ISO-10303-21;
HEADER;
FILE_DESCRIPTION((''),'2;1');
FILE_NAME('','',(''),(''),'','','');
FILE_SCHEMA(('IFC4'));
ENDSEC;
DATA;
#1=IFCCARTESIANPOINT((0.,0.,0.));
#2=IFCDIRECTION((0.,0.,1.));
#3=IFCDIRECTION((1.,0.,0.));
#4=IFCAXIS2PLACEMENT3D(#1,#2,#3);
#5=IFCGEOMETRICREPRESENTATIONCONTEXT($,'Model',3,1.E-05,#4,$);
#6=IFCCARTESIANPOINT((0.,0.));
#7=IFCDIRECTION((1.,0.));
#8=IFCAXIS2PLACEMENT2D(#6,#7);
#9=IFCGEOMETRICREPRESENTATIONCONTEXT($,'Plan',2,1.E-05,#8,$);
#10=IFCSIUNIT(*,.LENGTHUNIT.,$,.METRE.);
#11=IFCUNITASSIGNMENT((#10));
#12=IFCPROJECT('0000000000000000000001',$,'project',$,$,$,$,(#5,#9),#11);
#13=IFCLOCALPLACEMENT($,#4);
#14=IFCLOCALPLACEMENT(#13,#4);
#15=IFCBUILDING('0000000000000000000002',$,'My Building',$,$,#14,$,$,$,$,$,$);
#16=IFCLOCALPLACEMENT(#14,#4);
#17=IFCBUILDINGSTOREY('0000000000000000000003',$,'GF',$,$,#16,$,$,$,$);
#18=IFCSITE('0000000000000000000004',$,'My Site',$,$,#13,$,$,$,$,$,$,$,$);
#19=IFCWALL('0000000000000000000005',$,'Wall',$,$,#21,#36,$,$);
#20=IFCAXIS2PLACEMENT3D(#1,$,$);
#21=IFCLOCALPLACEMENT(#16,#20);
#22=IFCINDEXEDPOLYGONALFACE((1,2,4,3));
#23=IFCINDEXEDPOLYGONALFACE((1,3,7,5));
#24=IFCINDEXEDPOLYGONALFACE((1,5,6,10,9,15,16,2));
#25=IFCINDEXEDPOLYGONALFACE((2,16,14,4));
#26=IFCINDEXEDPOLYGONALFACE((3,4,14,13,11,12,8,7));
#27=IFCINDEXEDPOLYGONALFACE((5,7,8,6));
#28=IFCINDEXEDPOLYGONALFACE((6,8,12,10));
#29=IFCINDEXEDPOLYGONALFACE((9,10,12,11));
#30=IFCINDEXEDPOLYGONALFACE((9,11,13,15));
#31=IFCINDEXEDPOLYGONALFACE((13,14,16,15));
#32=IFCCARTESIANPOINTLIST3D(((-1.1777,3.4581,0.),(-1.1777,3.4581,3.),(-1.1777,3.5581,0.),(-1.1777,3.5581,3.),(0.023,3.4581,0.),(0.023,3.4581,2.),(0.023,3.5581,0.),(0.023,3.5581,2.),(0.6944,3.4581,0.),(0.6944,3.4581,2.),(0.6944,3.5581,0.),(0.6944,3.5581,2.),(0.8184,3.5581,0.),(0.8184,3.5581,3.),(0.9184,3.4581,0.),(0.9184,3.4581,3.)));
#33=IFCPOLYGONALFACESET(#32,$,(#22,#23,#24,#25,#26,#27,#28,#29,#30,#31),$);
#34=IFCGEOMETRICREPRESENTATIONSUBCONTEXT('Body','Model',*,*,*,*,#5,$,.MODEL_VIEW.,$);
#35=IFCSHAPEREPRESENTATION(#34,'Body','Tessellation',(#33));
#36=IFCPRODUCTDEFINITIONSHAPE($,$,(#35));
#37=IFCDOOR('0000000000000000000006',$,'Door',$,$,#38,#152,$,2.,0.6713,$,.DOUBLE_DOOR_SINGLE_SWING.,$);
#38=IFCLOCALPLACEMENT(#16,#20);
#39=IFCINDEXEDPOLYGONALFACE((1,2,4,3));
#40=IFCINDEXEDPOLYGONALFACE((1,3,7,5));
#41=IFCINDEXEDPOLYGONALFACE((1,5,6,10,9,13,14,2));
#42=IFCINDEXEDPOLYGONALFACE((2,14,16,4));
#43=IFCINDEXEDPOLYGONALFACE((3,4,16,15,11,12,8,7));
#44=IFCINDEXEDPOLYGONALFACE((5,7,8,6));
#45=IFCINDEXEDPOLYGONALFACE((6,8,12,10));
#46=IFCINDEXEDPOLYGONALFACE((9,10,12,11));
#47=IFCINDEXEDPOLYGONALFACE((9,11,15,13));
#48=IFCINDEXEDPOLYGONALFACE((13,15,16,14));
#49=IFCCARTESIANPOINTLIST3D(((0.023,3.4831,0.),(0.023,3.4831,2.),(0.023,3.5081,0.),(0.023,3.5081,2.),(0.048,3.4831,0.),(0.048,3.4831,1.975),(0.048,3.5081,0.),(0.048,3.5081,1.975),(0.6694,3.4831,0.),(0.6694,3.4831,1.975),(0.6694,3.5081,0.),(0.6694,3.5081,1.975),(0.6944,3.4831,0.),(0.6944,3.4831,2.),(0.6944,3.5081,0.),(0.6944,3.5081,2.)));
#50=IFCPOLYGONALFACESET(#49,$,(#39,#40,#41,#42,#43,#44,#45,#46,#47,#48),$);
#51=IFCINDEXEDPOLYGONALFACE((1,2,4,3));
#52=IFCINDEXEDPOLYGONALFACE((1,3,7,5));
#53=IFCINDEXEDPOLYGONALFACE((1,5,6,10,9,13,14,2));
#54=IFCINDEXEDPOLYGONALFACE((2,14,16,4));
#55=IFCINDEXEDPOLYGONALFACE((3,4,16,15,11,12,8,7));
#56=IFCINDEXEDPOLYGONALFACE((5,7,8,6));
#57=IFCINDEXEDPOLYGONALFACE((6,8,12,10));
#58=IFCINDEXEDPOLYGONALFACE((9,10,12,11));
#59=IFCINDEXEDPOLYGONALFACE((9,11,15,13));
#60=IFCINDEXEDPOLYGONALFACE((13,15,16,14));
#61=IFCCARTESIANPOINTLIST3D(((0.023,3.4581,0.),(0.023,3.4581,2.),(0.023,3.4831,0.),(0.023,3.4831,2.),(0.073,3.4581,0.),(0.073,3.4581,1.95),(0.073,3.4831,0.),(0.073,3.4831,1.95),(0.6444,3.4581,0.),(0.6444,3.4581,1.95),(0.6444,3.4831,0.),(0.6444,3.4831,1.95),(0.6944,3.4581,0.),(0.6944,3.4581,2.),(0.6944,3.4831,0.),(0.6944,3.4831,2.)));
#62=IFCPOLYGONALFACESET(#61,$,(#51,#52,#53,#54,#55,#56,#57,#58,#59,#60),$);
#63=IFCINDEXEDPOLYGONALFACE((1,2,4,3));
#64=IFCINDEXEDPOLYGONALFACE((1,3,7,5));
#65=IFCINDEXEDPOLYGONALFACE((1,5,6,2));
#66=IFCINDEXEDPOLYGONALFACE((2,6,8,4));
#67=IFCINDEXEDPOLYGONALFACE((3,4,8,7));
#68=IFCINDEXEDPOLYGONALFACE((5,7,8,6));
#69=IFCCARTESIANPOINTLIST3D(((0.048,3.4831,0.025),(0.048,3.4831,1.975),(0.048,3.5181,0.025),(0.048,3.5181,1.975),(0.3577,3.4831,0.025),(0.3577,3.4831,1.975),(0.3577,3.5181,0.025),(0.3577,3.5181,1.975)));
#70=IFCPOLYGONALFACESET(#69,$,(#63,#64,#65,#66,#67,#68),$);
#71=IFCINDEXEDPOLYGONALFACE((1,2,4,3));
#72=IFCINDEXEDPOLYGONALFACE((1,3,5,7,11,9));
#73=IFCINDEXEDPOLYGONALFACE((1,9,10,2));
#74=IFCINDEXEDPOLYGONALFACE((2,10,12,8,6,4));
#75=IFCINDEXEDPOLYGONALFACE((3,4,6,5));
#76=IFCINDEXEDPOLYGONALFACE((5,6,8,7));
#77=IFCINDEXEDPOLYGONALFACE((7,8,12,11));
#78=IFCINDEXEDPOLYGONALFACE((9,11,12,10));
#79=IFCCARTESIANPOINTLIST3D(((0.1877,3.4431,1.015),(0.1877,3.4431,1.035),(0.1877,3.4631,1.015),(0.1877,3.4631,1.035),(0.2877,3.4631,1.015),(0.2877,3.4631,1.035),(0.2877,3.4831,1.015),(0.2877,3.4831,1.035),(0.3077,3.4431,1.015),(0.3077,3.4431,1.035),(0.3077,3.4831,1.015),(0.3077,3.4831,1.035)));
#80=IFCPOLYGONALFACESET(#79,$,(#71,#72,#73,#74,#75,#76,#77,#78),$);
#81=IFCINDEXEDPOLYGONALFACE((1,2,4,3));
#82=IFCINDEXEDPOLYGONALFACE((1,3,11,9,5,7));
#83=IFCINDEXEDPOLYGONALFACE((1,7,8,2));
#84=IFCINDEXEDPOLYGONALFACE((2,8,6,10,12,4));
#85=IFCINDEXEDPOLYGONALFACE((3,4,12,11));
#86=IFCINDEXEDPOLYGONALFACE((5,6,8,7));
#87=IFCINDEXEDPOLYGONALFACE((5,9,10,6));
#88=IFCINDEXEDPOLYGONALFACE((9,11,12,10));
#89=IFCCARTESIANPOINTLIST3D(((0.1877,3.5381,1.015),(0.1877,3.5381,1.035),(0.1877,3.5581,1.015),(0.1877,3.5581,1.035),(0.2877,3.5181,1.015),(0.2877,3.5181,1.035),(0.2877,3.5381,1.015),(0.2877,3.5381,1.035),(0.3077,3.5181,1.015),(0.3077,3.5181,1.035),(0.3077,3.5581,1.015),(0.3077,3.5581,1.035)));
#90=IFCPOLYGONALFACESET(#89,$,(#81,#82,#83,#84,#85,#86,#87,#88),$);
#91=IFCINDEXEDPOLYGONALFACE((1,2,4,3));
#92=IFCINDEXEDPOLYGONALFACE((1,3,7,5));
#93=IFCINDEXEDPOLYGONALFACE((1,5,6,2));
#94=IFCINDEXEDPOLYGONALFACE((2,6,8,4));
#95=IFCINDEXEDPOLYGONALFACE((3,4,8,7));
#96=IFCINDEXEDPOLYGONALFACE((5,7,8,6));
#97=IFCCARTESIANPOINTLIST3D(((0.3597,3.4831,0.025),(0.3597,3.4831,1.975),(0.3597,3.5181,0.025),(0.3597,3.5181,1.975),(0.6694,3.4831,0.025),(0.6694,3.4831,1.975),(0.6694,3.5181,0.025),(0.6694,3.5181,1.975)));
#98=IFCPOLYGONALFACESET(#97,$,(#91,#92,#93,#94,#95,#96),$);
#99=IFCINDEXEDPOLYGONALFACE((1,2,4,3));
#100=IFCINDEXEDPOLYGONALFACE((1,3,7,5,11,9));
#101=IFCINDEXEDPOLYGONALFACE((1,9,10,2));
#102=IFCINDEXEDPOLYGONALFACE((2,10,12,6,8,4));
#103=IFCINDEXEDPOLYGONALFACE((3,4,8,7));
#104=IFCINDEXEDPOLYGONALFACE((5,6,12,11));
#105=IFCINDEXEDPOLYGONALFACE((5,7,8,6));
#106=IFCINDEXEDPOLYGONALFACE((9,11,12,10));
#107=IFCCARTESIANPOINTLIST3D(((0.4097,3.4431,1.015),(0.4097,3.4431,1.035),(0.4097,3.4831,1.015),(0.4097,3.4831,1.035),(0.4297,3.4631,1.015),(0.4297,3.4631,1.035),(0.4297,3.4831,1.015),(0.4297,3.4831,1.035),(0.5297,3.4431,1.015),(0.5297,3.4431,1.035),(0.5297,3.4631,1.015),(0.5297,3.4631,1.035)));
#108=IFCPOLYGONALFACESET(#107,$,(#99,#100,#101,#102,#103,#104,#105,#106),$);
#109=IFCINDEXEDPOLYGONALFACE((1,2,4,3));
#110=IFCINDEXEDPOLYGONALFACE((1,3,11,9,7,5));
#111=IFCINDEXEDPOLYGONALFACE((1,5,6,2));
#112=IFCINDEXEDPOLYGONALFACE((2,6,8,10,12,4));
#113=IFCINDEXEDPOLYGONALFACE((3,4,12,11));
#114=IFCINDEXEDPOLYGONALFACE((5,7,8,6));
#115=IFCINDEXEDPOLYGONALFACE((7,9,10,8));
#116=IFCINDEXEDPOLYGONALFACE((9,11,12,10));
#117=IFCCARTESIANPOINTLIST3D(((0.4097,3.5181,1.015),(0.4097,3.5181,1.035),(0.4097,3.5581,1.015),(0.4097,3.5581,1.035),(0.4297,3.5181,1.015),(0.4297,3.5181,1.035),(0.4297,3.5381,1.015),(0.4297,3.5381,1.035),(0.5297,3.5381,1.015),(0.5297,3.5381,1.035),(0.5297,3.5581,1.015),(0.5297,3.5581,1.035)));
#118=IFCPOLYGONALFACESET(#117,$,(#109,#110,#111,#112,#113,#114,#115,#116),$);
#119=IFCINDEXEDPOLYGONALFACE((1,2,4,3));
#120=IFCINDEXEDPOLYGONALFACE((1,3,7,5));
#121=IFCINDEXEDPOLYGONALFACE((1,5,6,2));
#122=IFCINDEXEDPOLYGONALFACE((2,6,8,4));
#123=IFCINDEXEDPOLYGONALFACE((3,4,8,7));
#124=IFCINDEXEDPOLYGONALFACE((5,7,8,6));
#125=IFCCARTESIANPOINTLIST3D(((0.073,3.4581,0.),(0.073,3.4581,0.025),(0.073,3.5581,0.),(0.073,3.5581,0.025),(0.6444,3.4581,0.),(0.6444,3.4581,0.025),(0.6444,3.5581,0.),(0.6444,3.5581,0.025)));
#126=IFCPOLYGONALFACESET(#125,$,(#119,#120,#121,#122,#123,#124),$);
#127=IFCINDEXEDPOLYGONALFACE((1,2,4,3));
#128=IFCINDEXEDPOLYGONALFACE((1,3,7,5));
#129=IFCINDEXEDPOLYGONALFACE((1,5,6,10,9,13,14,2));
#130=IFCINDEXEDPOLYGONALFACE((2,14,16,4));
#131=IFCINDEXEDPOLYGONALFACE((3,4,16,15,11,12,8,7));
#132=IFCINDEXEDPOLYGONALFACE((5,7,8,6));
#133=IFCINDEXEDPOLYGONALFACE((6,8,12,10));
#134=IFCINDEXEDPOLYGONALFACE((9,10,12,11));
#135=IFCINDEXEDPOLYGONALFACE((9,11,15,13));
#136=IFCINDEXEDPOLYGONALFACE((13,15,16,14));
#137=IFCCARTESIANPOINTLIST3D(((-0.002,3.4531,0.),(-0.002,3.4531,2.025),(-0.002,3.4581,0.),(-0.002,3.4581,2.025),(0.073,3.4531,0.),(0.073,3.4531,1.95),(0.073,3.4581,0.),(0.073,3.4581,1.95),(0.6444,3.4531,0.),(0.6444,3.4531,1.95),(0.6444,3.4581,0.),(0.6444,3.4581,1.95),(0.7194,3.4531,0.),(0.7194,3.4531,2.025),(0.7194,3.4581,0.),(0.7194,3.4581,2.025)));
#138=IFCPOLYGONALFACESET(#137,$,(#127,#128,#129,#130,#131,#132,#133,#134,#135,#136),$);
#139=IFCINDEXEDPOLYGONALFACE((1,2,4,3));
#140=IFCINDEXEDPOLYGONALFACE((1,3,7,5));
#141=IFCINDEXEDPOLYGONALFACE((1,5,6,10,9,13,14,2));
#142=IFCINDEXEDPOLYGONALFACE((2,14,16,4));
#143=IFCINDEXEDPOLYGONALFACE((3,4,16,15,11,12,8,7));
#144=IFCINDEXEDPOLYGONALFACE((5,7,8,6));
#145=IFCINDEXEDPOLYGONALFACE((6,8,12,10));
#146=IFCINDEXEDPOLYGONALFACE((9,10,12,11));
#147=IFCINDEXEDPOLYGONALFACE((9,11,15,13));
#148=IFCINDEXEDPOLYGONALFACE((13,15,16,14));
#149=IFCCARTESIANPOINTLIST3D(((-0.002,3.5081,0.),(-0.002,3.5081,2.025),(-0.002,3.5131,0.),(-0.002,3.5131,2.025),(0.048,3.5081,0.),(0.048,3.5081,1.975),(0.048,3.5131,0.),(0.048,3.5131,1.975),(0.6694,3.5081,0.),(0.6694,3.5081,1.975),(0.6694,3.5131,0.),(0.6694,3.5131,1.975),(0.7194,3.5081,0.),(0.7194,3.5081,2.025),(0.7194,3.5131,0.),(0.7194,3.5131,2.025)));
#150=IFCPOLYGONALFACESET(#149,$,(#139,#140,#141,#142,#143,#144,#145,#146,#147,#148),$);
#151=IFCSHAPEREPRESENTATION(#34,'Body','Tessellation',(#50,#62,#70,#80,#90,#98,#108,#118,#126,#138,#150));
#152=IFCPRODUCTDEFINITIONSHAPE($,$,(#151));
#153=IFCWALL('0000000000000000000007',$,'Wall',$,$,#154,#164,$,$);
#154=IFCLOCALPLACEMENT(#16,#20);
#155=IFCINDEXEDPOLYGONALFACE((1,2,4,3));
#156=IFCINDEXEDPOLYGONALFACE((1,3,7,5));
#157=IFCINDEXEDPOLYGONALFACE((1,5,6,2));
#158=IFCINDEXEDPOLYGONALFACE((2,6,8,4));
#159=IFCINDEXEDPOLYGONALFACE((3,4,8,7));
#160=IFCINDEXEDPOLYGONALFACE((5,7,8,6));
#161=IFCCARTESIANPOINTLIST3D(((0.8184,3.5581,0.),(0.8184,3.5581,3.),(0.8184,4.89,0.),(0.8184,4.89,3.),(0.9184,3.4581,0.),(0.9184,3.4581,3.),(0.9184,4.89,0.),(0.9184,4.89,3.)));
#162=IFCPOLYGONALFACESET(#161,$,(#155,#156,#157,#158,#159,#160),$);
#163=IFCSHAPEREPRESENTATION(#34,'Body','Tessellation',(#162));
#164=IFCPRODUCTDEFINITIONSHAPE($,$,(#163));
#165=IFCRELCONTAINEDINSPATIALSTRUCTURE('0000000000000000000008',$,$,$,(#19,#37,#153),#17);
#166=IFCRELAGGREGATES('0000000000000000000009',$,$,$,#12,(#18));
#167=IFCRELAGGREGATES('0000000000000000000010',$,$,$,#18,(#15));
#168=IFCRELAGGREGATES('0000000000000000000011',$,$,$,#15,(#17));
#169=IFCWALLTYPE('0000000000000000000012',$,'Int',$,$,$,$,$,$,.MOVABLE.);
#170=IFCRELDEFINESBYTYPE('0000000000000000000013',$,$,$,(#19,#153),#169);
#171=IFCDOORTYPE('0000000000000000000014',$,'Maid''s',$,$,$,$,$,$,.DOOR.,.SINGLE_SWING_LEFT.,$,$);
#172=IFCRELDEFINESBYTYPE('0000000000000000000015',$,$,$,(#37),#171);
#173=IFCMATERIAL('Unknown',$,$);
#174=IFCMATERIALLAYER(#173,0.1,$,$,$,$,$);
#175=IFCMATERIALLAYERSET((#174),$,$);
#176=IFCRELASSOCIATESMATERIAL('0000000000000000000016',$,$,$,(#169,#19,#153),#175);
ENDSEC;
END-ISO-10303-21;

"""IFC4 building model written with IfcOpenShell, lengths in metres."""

from ifc_helpers import new_model, entity, si_unit, frame, origin_with_axes, origin_2d_with_axis, place, context, subcontext, project, spatial, line, indexed_curve, outline, extrude, shape, source, transform, mapped, material, layer, layer_set, layer_usage, type_object, type_shapes, element, fill, save


model = new_model("IFC4")

# Units and contexts
model_context = context("Model", 3, precision=1e-05, world=origin_with_axes())
plan_context = context("Plan", 2, precision=1e-05, world=origin_2d_with_axis())
body_context_1 = subcontext(model_context, "Body", "Model", "MODEL_VIEW")
body_context_2 = subcontext(plan_context, "Body", "Plan", "PLAN_VIEW")
ifc_project = project(units=[si_unit("LENGTHUNIT", "METRE")], contexts=[model_context, plan_context])

# Site, building, storey
site_placement = place(None, origin_with_axes())
site = spatial("IfcSite", under=ifc_project, at=site_placement, Name="My Site")
building_placement = place(site_placement, origin_with_axes())
building = spatial("IfcBuilding", under=site, at=building_placement, Name="My Building")
storey_placement = place(building_placement, origin_with_axes())
storey = spatial("IfcBuildingStorey", under=building, at=storey_placement, Name="GF")

# Shared definitions
ifc_material = material(Name="Unknown")

# Shared definitions
ifc_layer_1 = layer(ifc_material, 0.1)
ifc_layer_set_1 = layer_set([ifc_layer_1])
wall_type_1 = type_object("IfcWallType", Name="Int", PredefinedType="MOVABLE", material=ifc_layer_set_1)

# Wall, opening, door
ifc_layer_usage_1 = layer_usage(ifc_layer_set_1, "AXIS2", "POSITIVE", 0.0)
wall_1_placement = place(storey_placement, frame((-1.1777, 3.4581, 0.0), z_axis=(0.0, 0.0, 1.0), x_axis=(1.0, 0.0, 0.0)))
wall_1 = element("IfcWall", 1, at=wall_1_placement, inside=storey, type_object=wall_type_1, material=ifc_layer_usage_1, Name="Wall", context=body_context_1, shape_type="SweptSolid", body=[
    extrude(outline(indexed_curve([(0.0, 0.0), (0.0, 0.1), (1.9961, 0.1), (2.0961, 0.0)], segments=[line(1, 2, 3, 4, 1)])), origin_with_axes(), (0.0, 0.0, 1.0), 3.0),
])
shared_shape_1 = source(origin_with_axes(), body_context_1, "Body", "SweptSolid", [
    extrude(outline(indexed_curve([(0.0, 0.0), (0.6713, 0.0), (0.6713, 2.0), (0.0, 2.0)], segments=[line(1, 2, 3, 4, 1)])), frame((0.0, -0.6, 0.0), z_axis=(0.0, -1.0, 0.0), x_axis=(1.0, 0.0, 0.0)), (0.0, 0.0, -1.0), 1.2),
])
opening_1_placement = place(wall_1_placement, frame((1.2007, 0.0, 0.0), z_axis=(0.0, 0.0, 1.0), x_axis=(1.0, 0.0, 0.0)))
opening_1 = element("IfcOpeningElement", 2, at=opening_1_placement, cuts=wall_1, PredefinedType="OPENING", context=body_context_1, shape_type="MappedRepresentation", body=[
    mapped(shared_shape_1, transform((0.0, 0.0, 0.0), x_axis=(1.0, 0.0, 0.0), y_axis=(0.0, 1.0, 0.0), z_axis=(0.0, 0.0, 1.0), scale=1.0)),
])
door_type_1 = type_object("IfcDoorType", Name="Maid's", OperationType="SINGLE_SWING_LEFT", PredefinedType="DOOR")
shared_shape_2 = source(origin_with_axes(), body_context_1, "Body", "SweptSolid", [
    extrude(outline(indexed_curve([(0.0, 0.0), (0.0, 2.0), (0.6713, 2.0), (0.6713, 0.0), (0.6463, 0.0), (0.6463, 1.975), (0.025, 1.975), (0.025, 0.0)], segments=[line(1, 2, 3, 4, 5, 6, 7, 8, 1)])), frame((0.0, 0.025, 0.0), z_axis=(0.0, -1.0, 0.0), x_axis=(1.0, 0.0, 0.0)), (0.0, 0.0, -1.0), 0.025),
    extrude(outline(indexed_curve([(0.0, 0.0), (0.0, 2.0), (0.6713, 2.0), (0.6713, 0.0), (0.6213, 0.0), (0.6213, 1.95), (0.05, 1.95), (0.05, 0.0)], segments=[line(1, 2, 3, 4, 5, 6, 7, 8, 1)])), frame((0.0, 0.0, 0.0), z_axis=(0.0, -1.0, 0.0), x_axis=(1.0, 0.0, 0.0)), (0.0, 0.0, -1.0), 0.025),
    extrude(outline(indexed_curve([(0.0, 0.0), (0.3097, 0.0), (0.3097, 0.035), (0.0, 0.035)], segments=[line(1, 2, 3, 4, 1)])), frame((0.025, 0.025, 0.025), z_axis=(0.0, 0.0, 1.0), x_axis=(1.0, 0.0, 0.0)), (0.0, 0.0, 1.0), 1.95),
    extrude(outline(indexed_curve([(0.0, 0.0), (0.0, -0.04), (-0.12, -0.04), (-0.12, -0.02), (-0.02, -0.02), (-0.02, 0.0)], segments=[line(1, 2, 3, 4, 5, 6, 1)])), frame((0.2847, 0.025, 1.015), z_axis=(0.0, 0.0, 1.0), x_axis=(1.0, 0.0, 0.0)), (0.0, 0.0, 1.0), 0.02),
    extrude(outline(indexed_curve([(0.0, 0.0), (0.0, 0.04), (-0.12, 0.04), (-0.12, 0.02), (-0.02, 0.02), (-0.02, 0.0)], segments=[line(1, 2, 3, 4, 5, 6, 1)])), frame((0.2847, 0.06, 1.015), z_axis=(0.0, 0.0, 1.0), x_axis=(1.0, 0.0, 0.0)), (0.0, 0.0, 1.0), 0.02),
    extrude(outline(indexed_curve([(0.0, 0.0), (-0.3097, 0.0), (-0.3097, 0.035), (0.0, 0.035)], segments=[line(1, 2, 3, 4, 1)])), frame((0.6463, 0.025, 0.025), z_axis=(0.0, 0.0, 1.0), x_axis=(1.0, 0.0, 0.0)), (0.0, 0.0, 1.0), 1.95),
    extrude(outline(indexed_curve([(0.0, 0.0), (0.0, -0.04), (0.12, -0.04), (0.12, -0.02), (0.02, -0.02), (0.02, 0.0)], segments=[line(1, 2, 3, 4, 5, 6, 1)])), frame((0.3867, 0.025, 1.015), z_axis=(0.0, 0.0, 1.0), x_axis=(1.0, 0.0, 0.0)), (0.0, 0.0, 1.0), 0.02),
    extrude(outline(indexed_curve([(0.0, 0.0), (0.0, 0.04), (0.12, 0.04), (0.12, 0.02), (0.02, 0.02), (0.02, 0.0)], segments=[line(1, 2, 3, 4, 5, 6, 1)])), frame((0.3867, 0.06, 1.015), z_axis=(0.0, 0.0, 1.0), x_axis=(1.0, 0.0, 0.0)), (0.0, 0.0, 1.0), 0.02),
    extrude(outline(indexed_curve([(0.0, 0.1), (0.5713, 0.1), (0.5713, 0.0), (0.0, 0.0), (0.0, 0.1)])), frame((0.05, 0.0, 0.0), z_axis=(0.0, 0.0, 1.0), x_axis=(1.0, 0.0, 0.0)), (0.0, 0.0, 1.0), 0.025),
    extrude(outline(indexed_curve([(0.075, 0.0), (0.075, 1.95), (0.6463, 1.95), (0.6463, 0.0), (0.7213, 0.0), (0.7213, 2.025), (0.0, 2.025), (0.0, 0.0), (0.075, 0.0)])), frame((-0.025, -0.005, 0.0), z_axis=(0.0, -1.0, 0.0), x_axis=(1.0, 0.0, 0.0)), (0.0, 0.0, -1.0), 0.005),
    extrude(outline(indexed_curve([(0.0, 0.0), (0.0, 2.025), (0.7213, 2.025), (0.7213, 0.0), (0.6713, 0.0), (0.6713, 1.975), (0.05, 1.975), (0.05, 0.0)], segments=[line(1, 2, 3, 4, 5, 6, 7, 8, 1)])), frame((-0.025, 0.05, 0.0), z_axis=(0.0, -1.0, 0.0), x_axis=(1.0, 0.0, 0.0)), (0.0, 0.0, -1.0), 0.005),
])
shared_shape_3 = source(origin_with_axes(), body_context_2, "Body", "Curve2D", [
    entity("IfcIndexedPolyCurve", entity("IfcCartesianPointList2D", [[0.0, 0.0], [0.0, 0.05], [0.025, 0.05], [0.025, 0.025], [0.05, 0.025], [0.05, 0.0]]), [entity("IfcLineIndex", [1, 2, 3, 4, 5, 6, 1])]),
    entity("IfcIndexedPolyCurve", entity("IfcCartesianPointList2D", [[0.6713, 0.0], [0.6713, 0.05], [0.6463, 0.05], [0.6463, 0.025], [0.6213, 0.025], [0.6213, 0.0]]), [entity("IfcLineIndex", [1, 2, 3, 4, 5, 6, 1])]),
    entity("IfcTrimmedCurve", entity("IfcEllipse", entity("IfcAxis2Placement2D", entity("IfcCartesianPoint", [0.06, 0.05]), entity("IfcDirection", [1.0, 0.0])), 0.2757, 0.3107), [entity("IfcCartesianPoint", [0.3357, 0.05])], [entity("IfcCartesianPoint", [0.06, 0.3607])], True, "CARTESIAN"),
    entity("IfcIndexedPolyCurve", entity("IfcCartesianPointList2D", [[0.025, 0.05], [0.06, 0.05], [0.06, 0.3607], [0.025, 0.3607]]), [entity("IfcLineIndex", [1, 2, 3, 4, 1])]),
    entity("IfcTrimmedCurve", entity("IfcEllipse", entity("IfcAxis2Placement2D", entity("IfcCartesianPoint", [0.6113, 0.05]), entity("IfcDirection", [1.0, 0.0])), 0.2757, 0.3107), [entity("IfcCartesianPoint", [0.6113, 0.3607])], [entity("IfcCartesianPoint", [0.3357, 0.05])], True, "CARTESIAN"),
    entity("IfcIndexedPolyCurve", entity("IfcCartesianPointList2D", [[0.6463, 0.05], [0.6113, 0.05], [0.6113, 0.3607], [0.6463, 0.3607]]), [entity("IfcLineIndex", [1, 2, 3, 4, 1])]),
])
type_shapes(door_type_1, [shared_shape_2, shared_shape_3])
door_1_placement = place(opening_1_placement, origin_with_axes())
door_1 = element("IfcDoor", 3, at=door_1_placement, inside=storey, type_object=door_type_1, Name="Door", OperationType="DOUBLE_DOOR_SINGLE_SWING", OverallHeight=2.0, OverallWidth=0.6713, shapes=[
    shape(body_context_1, "Body", "MappedRepresentation", [mapped(shared_shape_2, transform((0.0, 0.0, 0.0), x_axis=(1.0, 0.0, 0.0), y_axis=(0.0, 1.0, 0.0), z_axis=(0.0, 0.0, 1.0), scale=1.0))]),
    shape(body_context_2, "Body", "MappedRepresentation", [mapped(shared_shape_3, transform((0.0, 0.0, 0.0), x_axis=(1.0, 0.0, 0.0), y_axis=(0.0, 1.0, 0.0), z_axis=(0.0, 0.0, 1.0), scale=1.0))]),
])
fill(opening_1, door_1)

# Wall
ifc_layer_usage_2 = layer_usage(ifc_layer_set_1, "AXIS2", "POSITIVE", 0.0)
wall_2_placement = place(storey_placement, frame((0.9184, 3.4581, 0.0), z_axis=(0.0, 0.0, 1.0), x_axis=(0.0, 1.0, 0.0)))
element("IfcWall", 4, at=wall_2_placement, inside=storey, type_object=wall_type_1, material=ifc_layer_usage_2, Name="Wall", context=body_context_1, shape_type="SweptSolid", body=[
    extrude(outline(indexed_curve([(0.0, 0.0), (0.1, 0.1), (1.4319, 0.1), (1.4319, 0.0)], segments=[line(1, 2, 3, 4, 1)])), origin_with_axes(), (0.0, 0.0, 1.0), 3.0),
])

save(model, "model.ifc")
